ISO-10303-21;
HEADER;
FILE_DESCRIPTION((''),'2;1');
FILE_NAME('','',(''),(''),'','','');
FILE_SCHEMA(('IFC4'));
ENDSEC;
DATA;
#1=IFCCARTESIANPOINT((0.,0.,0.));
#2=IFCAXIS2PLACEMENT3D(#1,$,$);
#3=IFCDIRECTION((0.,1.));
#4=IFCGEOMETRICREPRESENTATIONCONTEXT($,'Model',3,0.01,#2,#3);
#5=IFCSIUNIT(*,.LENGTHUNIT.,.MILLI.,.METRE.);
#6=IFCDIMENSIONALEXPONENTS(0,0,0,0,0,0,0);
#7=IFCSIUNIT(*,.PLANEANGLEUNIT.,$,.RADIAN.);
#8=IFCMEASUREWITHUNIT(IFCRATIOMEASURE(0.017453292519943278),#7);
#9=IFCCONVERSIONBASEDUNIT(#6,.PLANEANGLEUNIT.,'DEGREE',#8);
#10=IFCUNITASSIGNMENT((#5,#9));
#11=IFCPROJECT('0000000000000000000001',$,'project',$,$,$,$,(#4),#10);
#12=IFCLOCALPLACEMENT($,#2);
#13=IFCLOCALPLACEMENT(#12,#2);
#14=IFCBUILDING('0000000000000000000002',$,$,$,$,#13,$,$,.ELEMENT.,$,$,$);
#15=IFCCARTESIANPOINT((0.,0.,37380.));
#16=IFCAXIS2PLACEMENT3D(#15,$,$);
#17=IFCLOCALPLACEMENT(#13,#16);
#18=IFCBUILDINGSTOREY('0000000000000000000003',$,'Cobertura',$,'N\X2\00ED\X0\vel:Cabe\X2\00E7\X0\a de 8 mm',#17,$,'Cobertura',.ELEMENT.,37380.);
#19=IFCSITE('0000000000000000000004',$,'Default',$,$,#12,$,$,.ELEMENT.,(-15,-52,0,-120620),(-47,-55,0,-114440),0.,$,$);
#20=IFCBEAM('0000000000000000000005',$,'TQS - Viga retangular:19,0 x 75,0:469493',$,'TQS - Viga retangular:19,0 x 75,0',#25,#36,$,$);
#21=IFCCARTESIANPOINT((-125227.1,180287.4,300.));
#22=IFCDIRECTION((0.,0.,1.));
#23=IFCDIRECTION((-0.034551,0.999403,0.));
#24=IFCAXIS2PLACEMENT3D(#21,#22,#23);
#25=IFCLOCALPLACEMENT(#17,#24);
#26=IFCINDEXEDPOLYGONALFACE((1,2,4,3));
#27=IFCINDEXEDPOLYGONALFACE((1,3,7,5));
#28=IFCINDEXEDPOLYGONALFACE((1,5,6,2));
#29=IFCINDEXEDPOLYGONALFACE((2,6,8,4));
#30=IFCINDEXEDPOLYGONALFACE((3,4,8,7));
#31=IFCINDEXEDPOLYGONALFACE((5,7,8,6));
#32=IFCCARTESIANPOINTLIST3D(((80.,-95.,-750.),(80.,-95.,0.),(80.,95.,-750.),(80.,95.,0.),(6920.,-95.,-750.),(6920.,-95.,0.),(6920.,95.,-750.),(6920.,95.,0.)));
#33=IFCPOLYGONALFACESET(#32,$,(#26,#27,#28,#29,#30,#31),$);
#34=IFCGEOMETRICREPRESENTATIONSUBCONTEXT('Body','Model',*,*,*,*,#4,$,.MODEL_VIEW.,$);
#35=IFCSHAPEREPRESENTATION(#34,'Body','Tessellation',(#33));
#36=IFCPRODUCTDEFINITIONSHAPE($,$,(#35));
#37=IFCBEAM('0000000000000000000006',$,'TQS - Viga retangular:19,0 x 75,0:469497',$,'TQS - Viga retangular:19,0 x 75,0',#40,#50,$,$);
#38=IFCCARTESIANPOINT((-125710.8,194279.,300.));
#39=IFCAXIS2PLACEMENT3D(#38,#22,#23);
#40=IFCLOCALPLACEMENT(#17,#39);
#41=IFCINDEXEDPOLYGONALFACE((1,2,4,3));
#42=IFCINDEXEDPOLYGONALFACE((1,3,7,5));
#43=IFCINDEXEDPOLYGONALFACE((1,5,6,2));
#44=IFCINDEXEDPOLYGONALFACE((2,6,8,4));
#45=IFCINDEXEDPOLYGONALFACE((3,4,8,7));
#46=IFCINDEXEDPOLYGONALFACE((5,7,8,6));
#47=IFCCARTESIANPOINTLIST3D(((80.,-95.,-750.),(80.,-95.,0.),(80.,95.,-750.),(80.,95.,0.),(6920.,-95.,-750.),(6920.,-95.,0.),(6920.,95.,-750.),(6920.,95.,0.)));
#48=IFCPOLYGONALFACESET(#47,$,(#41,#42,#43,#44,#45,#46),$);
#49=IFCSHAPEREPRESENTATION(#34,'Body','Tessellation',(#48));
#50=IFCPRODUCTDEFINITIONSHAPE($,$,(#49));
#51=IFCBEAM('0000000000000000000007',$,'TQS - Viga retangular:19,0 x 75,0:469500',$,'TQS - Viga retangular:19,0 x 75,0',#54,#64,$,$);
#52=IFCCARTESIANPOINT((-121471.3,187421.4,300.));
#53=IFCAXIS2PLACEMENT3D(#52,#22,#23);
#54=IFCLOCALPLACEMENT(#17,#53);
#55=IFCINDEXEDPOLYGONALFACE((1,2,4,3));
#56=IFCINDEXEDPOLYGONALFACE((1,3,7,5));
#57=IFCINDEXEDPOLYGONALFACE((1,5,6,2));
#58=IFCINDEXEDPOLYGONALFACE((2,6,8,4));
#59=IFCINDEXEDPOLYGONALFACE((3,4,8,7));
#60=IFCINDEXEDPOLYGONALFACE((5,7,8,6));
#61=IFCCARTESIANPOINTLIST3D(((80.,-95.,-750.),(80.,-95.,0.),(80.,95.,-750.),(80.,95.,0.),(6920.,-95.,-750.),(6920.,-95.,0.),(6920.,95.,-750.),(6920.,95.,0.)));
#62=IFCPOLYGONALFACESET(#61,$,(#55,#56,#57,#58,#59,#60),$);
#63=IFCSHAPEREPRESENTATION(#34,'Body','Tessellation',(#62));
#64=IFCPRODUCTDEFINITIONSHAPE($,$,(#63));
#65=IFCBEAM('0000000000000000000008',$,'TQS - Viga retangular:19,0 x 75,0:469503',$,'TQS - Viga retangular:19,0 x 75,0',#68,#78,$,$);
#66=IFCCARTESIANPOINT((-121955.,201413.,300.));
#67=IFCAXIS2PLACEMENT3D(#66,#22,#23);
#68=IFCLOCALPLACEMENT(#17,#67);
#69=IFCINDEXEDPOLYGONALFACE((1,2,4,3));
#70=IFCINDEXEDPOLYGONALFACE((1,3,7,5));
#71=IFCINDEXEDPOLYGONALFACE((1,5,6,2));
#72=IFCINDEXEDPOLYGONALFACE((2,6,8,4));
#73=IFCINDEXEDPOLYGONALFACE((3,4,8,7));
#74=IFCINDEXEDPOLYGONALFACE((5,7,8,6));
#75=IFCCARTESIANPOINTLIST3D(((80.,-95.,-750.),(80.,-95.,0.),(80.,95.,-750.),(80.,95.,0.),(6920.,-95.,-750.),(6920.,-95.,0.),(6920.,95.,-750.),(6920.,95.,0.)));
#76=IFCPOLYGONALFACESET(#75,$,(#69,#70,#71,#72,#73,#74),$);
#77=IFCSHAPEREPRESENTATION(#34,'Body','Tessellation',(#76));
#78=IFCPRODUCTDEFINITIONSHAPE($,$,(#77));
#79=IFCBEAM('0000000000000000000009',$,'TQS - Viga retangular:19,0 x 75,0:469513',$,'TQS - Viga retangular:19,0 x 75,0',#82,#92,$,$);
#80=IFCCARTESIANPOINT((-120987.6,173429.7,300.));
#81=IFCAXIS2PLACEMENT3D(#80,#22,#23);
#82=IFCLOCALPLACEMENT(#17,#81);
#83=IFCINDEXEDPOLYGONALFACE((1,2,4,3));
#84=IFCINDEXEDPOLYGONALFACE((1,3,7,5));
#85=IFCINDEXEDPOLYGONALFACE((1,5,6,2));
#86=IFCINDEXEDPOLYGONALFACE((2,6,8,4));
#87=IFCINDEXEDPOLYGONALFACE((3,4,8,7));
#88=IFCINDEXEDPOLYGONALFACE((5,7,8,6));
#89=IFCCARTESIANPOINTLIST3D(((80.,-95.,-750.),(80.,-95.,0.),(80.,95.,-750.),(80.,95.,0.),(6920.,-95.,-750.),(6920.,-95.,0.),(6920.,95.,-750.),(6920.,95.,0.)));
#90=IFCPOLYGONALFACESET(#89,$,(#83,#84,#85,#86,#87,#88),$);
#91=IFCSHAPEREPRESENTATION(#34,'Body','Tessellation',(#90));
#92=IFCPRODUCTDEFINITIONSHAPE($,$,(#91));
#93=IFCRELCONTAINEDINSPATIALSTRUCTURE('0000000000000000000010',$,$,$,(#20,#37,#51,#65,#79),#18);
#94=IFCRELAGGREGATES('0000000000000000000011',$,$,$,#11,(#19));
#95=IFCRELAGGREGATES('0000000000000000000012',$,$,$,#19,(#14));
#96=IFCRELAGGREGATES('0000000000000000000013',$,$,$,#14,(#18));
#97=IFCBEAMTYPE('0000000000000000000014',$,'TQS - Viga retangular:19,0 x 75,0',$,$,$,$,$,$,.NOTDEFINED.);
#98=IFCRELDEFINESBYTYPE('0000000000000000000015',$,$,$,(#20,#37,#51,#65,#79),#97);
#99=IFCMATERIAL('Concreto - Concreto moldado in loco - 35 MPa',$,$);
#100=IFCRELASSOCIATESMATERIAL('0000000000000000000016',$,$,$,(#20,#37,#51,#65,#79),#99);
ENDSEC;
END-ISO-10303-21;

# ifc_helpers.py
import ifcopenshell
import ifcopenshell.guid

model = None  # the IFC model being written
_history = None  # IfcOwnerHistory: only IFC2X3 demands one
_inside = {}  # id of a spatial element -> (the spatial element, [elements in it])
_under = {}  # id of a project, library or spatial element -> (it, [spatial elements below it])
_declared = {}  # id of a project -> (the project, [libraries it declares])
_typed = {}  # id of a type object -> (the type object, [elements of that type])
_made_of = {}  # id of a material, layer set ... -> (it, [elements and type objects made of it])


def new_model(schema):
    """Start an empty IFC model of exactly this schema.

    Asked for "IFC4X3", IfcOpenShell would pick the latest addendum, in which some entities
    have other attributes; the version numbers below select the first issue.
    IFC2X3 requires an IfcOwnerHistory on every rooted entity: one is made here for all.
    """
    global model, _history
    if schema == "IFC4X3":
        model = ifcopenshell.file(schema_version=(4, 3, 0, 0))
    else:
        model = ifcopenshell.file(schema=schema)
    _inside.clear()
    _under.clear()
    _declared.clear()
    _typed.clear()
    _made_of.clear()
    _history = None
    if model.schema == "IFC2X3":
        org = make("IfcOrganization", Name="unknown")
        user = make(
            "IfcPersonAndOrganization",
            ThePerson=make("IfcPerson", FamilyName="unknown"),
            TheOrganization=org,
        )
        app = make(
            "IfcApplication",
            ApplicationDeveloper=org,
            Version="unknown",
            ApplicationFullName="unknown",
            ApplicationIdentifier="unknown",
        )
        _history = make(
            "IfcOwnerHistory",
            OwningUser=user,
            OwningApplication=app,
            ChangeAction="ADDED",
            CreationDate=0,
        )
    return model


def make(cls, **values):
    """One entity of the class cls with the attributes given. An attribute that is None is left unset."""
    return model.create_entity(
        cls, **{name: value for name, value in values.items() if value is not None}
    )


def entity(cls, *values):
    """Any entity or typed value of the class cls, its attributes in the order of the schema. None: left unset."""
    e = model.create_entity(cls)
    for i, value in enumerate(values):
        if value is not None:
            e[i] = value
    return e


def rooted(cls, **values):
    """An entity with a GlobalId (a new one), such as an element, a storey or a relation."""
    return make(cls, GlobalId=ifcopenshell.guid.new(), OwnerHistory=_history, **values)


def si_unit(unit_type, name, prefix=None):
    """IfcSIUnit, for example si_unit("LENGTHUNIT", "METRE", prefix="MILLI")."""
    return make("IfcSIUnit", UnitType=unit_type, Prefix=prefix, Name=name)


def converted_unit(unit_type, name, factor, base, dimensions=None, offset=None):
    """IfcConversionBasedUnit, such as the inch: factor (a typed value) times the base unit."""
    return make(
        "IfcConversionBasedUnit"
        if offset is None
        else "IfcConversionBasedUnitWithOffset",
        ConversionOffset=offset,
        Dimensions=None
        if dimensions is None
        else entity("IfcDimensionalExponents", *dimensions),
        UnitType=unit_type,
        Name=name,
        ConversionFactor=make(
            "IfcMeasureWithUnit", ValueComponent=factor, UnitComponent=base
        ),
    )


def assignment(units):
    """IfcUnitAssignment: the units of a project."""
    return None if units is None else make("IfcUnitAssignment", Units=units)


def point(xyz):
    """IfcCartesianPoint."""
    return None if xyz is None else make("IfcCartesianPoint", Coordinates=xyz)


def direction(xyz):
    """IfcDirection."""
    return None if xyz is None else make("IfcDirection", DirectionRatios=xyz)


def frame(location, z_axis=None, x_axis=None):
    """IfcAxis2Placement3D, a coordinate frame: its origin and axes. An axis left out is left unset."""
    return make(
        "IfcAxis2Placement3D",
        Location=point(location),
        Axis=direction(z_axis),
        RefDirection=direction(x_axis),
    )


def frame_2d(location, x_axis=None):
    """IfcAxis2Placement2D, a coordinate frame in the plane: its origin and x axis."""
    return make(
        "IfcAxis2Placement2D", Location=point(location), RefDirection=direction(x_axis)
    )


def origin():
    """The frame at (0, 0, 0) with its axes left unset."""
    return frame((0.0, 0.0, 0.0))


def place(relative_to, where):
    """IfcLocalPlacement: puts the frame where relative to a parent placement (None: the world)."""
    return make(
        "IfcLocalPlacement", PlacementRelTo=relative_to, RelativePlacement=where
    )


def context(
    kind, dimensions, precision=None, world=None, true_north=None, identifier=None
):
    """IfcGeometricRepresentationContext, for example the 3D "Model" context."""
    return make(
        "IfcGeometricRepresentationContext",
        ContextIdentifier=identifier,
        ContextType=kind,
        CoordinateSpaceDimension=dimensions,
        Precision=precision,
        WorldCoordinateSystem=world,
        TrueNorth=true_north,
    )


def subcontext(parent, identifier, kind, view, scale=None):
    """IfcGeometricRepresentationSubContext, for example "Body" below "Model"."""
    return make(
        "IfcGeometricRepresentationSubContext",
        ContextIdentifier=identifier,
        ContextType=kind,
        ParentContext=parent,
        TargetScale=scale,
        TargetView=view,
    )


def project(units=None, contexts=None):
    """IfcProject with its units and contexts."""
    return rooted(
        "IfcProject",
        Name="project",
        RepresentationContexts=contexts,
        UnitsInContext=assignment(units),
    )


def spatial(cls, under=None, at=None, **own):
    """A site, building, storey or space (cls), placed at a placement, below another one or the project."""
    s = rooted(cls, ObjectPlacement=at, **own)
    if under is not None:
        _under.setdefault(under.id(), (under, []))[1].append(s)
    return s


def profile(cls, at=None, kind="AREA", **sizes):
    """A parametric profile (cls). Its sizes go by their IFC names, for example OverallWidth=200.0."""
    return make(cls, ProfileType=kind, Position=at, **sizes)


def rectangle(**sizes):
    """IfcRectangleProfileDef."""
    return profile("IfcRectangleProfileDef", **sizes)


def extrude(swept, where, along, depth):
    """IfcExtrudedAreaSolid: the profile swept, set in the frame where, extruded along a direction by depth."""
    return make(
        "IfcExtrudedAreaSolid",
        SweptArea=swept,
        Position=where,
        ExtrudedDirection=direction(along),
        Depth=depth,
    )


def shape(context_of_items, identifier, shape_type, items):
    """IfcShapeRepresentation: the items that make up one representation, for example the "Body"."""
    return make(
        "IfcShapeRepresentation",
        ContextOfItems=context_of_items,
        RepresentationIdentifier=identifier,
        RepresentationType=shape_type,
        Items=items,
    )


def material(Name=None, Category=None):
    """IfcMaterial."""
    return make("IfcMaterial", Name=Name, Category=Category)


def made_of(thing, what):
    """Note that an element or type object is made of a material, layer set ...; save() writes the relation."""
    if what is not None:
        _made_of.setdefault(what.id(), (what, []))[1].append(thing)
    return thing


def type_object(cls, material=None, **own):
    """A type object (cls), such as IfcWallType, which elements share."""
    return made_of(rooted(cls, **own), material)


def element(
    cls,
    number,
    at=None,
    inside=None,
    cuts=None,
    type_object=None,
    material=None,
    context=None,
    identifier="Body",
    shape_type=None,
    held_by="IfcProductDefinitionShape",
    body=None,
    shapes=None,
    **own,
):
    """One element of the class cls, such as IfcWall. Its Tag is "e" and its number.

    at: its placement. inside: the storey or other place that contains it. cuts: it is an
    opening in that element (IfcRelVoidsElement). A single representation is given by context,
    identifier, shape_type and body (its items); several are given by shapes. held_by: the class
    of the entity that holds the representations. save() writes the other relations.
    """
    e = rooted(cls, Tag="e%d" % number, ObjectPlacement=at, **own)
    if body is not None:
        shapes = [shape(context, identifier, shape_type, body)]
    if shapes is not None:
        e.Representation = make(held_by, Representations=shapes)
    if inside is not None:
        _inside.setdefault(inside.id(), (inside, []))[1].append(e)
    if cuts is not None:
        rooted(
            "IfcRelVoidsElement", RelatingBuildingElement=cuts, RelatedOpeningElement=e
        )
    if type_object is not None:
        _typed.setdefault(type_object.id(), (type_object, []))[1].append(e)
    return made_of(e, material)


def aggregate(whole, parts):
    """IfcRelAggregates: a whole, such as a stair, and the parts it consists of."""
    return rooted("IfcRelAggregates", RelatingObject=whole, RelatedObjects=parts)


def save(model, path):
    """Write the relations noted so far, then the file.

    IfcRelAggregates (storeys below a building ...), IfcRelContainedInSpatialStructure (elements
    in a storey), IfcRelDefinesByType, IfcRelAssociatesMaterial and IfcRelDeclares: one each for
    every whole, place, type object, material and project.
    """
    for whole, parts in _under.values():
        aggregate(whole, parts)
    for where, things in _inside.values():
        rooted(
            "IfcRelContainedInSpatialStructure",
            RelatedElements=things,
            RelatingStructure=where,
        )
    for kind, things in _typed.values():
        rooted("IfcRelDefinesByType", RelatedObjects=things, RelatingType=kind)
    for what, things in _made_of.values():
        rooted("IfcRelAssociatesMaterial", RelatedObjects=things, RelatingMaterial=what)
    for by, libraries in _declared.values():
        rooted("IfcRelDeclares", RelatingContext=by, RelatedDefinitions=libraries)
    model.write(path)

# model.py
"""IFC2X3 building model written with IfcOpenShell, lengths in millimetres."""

from ifc_helpers import new_model, entity, si_unit, converted_unit, direction, frame, frame_2d, origin, place, context, subcontext, project, spatial, rectangle, extrude, material, type_object, element, save


model = new_model("IFC2X3")

# Units and contexts
model_context = context("Model", 3, precision=0.01, world=origin(), true_north=direction((0.0, 1.0)))
body_context = subcontext(model_context, "Body", "Model", "MODEL_VIEW")
ifc_project = project(units=[si_unit("LENGTHUNIT", "METRE", prefix="MILLI"), converted_unit("PLANEANGLEUNIT", "DEGREE", entity("IfcRatioMeasure", 0.017453292519943278), si_unit("PLANEANGLEUNIT", "RADIAN"), dimensions=[0, 0, 0, 0, 0, 0, 0])], contexts=[model_context])

# Site, building, storey
site_placement = place(None, origin())
site = spatial("IfcSite", under=ifc_project, at=site_placement, Name="Default", CompositionType="ELEMENT", RefLatitude=(-15, -52, 0, -120620), RefLongitude=(-47, -55, 0, -114440), RefElevation=0.0)
building_placement = place(site_placement, origin())
building = spatial("IfcBuilding", under=site, at=building_placement, CompositionType="ELEMENT")
storey_placement = place(building_placement, frame((0.0, 0.0, 37380.0)))
storey = spatial("IfcBuildingStorey", under=building, at=storey_placement, Name="Cobertura", ObjectType="Nível:Cabeça de 8 mm", LongName="Cobertura", CompositionType="ELEMENT", Elevation=37380.0)

# Beams
ifc_material = material(Name="Concreto - Concreto moldado in loco - 35 MPa")
beam_type_1 = type_object("IfcBeamType", Name="TQS - Viga retangular:19,0 x 75,0", PredefinedType="NOTDEFINED")
beam_1_placement = place(storey_placement, frame((-125227.1, 180287.4, 300.0), z_axis=(0.0, 0.0, 1.0), x_axis=(-0.034551, 0.999403, 0.0)))
element("IfcBeam", 1, at=beam_1_placement, inside=storey, type_object=beam_type_1, material=ifc_material, Name="TQS - Viga retangular:19,0 x 75,0:469493", ObjectType="TQS - Viga retangular:19,0 x 75,0", context=body_context, shape_type="SweptSolid", body=[
    extrude(rectangle(XDim=750.0, YDim=190.0, at=frame_2d((0.0, 0.0), x_axis=(1.0, 0.0))), frame((80.0, 0.0, -375.0), z_axis=(1.0, 0.0, 0.0), x_axis=(0.0, 0.0, -1.0)), (0.0, 0.0, 1.0), 6840.0),
])
beam_2_placement = place(storey_placement, frame((-125710.8, 194279.0, 300.0), z_axis=(0.0, 0.0, 1.0), x_axis=(-0.034551, 0.999403, 0.0)))
element("IfcBeam", 2, at=beam_2_placement, inside=storey, type_object=beam_type_1, material=ifc_material, Name="TQS - Viga retangular:19,0 x 75,0:469497", ObjectType="TQS - Viga retangular:19,0 x 75,0", context=body_context, shape_type="SweptSolid", body=[
    extrude(rectangle(XDim=750.0, YDim=190.0, at=frame_2d((0.0, 0.0), x_axis=(1.0, 0.0))), frame((80.0, 0.0, -375.0), z_axis=(1.0, 0.0, 0.0), x_axis=(0.0, 0.0, -1.0)), (0.0, 0.0, 1.0), 6840.0),
])
beam_3_placement = place(storey_placement, frame((-121471.3, 187421.4, 300.0), z_axis=(0.0, 0.0, 1.0), x_axis=(-0.034551, 0.999403, 0.0)))
element("IfcBeam", 3, at=beam_3_placement, inside=storey, type_object=beam_type_1, material=ifc_material, Name="TQS - Viga retangular:19,0 x 75,0:469500", ObjectType="TQS - Viga retangular:19,0 x 75,0", context=body_context, shape_type="SweptSolid", body=[
    extrude(rectangle(XDim=750.0, YDim=190.0, at=frame_2d((0.0, 0.0), x_axis=(1.0, 0.0))), frame((80.0, 0.0, -375.0), z_axis=(1.0, 0.0, 0.0), x_axis=(0.0, 0.0, -1.0)), (0.0, 0.0, 1.0), 6840.0),
])
beam_4_placement = place(storey_placement, frame((-121955.0, 201413.0, 300.0), z_axis=(0.0, 0.0, 1.0), x_axis=(-0.034551, 0.999403, 0.0)))
element("IfcBeam", 4, at=beam_4_placement, inside=storey, type_object=beam_type_1, material=ifc_material, Name="TQS - Viga retangular:19,0 x 75,0:469503", ObjectType="TQS - Viga retangular:19,0 x 75,0", context=body_context, shape_type="SweptSolid", body=[
    extrude(rectangle(XDim=750.0, YDim=190.0, at=frame_2d((0.0, 0.0), x_axis=(1.0, 0.0))), frame((80.0, 0.0, -375.0), z_axis=(1.0, 0.0, 0.0), x_axis=(0.0, 0.0, -1.0)), (0.0, 0.0, 1.0), 6840.0),
])
beam_5_placement = place(storey_placement, frame((-120987.6, 173429.7, 300.0), z_axis=(0.0, 0.0, 1.0), x_axis=(-0.034551, 0.999403, 0.0)))
element("IfcBeam", 5, at=beam_5_placement, inside=storey, type_object=beam_type_1, material=ifc_material, Name="TQS - Viga retangular:19,0 x 75,0:469513", ObjectType="TQS - Viga retangular:19,0 x 75,0", context=body_context, shape_type="SweptSolid", body=[
    extrude(rectangle(XDim=750.0, YDim=190.0, at=frame_2d((0.0, 0.0), x_axis=(1.0, 0.0))), frame((80.0, 0.0, -375.0), z_axis=(1.0, 0.0, 0.0), x_axis=(0.0, 0.0, -1.0)), (0.0, 0.0, 1.0), 6840.0),
])

save(model, "model.ifc")
